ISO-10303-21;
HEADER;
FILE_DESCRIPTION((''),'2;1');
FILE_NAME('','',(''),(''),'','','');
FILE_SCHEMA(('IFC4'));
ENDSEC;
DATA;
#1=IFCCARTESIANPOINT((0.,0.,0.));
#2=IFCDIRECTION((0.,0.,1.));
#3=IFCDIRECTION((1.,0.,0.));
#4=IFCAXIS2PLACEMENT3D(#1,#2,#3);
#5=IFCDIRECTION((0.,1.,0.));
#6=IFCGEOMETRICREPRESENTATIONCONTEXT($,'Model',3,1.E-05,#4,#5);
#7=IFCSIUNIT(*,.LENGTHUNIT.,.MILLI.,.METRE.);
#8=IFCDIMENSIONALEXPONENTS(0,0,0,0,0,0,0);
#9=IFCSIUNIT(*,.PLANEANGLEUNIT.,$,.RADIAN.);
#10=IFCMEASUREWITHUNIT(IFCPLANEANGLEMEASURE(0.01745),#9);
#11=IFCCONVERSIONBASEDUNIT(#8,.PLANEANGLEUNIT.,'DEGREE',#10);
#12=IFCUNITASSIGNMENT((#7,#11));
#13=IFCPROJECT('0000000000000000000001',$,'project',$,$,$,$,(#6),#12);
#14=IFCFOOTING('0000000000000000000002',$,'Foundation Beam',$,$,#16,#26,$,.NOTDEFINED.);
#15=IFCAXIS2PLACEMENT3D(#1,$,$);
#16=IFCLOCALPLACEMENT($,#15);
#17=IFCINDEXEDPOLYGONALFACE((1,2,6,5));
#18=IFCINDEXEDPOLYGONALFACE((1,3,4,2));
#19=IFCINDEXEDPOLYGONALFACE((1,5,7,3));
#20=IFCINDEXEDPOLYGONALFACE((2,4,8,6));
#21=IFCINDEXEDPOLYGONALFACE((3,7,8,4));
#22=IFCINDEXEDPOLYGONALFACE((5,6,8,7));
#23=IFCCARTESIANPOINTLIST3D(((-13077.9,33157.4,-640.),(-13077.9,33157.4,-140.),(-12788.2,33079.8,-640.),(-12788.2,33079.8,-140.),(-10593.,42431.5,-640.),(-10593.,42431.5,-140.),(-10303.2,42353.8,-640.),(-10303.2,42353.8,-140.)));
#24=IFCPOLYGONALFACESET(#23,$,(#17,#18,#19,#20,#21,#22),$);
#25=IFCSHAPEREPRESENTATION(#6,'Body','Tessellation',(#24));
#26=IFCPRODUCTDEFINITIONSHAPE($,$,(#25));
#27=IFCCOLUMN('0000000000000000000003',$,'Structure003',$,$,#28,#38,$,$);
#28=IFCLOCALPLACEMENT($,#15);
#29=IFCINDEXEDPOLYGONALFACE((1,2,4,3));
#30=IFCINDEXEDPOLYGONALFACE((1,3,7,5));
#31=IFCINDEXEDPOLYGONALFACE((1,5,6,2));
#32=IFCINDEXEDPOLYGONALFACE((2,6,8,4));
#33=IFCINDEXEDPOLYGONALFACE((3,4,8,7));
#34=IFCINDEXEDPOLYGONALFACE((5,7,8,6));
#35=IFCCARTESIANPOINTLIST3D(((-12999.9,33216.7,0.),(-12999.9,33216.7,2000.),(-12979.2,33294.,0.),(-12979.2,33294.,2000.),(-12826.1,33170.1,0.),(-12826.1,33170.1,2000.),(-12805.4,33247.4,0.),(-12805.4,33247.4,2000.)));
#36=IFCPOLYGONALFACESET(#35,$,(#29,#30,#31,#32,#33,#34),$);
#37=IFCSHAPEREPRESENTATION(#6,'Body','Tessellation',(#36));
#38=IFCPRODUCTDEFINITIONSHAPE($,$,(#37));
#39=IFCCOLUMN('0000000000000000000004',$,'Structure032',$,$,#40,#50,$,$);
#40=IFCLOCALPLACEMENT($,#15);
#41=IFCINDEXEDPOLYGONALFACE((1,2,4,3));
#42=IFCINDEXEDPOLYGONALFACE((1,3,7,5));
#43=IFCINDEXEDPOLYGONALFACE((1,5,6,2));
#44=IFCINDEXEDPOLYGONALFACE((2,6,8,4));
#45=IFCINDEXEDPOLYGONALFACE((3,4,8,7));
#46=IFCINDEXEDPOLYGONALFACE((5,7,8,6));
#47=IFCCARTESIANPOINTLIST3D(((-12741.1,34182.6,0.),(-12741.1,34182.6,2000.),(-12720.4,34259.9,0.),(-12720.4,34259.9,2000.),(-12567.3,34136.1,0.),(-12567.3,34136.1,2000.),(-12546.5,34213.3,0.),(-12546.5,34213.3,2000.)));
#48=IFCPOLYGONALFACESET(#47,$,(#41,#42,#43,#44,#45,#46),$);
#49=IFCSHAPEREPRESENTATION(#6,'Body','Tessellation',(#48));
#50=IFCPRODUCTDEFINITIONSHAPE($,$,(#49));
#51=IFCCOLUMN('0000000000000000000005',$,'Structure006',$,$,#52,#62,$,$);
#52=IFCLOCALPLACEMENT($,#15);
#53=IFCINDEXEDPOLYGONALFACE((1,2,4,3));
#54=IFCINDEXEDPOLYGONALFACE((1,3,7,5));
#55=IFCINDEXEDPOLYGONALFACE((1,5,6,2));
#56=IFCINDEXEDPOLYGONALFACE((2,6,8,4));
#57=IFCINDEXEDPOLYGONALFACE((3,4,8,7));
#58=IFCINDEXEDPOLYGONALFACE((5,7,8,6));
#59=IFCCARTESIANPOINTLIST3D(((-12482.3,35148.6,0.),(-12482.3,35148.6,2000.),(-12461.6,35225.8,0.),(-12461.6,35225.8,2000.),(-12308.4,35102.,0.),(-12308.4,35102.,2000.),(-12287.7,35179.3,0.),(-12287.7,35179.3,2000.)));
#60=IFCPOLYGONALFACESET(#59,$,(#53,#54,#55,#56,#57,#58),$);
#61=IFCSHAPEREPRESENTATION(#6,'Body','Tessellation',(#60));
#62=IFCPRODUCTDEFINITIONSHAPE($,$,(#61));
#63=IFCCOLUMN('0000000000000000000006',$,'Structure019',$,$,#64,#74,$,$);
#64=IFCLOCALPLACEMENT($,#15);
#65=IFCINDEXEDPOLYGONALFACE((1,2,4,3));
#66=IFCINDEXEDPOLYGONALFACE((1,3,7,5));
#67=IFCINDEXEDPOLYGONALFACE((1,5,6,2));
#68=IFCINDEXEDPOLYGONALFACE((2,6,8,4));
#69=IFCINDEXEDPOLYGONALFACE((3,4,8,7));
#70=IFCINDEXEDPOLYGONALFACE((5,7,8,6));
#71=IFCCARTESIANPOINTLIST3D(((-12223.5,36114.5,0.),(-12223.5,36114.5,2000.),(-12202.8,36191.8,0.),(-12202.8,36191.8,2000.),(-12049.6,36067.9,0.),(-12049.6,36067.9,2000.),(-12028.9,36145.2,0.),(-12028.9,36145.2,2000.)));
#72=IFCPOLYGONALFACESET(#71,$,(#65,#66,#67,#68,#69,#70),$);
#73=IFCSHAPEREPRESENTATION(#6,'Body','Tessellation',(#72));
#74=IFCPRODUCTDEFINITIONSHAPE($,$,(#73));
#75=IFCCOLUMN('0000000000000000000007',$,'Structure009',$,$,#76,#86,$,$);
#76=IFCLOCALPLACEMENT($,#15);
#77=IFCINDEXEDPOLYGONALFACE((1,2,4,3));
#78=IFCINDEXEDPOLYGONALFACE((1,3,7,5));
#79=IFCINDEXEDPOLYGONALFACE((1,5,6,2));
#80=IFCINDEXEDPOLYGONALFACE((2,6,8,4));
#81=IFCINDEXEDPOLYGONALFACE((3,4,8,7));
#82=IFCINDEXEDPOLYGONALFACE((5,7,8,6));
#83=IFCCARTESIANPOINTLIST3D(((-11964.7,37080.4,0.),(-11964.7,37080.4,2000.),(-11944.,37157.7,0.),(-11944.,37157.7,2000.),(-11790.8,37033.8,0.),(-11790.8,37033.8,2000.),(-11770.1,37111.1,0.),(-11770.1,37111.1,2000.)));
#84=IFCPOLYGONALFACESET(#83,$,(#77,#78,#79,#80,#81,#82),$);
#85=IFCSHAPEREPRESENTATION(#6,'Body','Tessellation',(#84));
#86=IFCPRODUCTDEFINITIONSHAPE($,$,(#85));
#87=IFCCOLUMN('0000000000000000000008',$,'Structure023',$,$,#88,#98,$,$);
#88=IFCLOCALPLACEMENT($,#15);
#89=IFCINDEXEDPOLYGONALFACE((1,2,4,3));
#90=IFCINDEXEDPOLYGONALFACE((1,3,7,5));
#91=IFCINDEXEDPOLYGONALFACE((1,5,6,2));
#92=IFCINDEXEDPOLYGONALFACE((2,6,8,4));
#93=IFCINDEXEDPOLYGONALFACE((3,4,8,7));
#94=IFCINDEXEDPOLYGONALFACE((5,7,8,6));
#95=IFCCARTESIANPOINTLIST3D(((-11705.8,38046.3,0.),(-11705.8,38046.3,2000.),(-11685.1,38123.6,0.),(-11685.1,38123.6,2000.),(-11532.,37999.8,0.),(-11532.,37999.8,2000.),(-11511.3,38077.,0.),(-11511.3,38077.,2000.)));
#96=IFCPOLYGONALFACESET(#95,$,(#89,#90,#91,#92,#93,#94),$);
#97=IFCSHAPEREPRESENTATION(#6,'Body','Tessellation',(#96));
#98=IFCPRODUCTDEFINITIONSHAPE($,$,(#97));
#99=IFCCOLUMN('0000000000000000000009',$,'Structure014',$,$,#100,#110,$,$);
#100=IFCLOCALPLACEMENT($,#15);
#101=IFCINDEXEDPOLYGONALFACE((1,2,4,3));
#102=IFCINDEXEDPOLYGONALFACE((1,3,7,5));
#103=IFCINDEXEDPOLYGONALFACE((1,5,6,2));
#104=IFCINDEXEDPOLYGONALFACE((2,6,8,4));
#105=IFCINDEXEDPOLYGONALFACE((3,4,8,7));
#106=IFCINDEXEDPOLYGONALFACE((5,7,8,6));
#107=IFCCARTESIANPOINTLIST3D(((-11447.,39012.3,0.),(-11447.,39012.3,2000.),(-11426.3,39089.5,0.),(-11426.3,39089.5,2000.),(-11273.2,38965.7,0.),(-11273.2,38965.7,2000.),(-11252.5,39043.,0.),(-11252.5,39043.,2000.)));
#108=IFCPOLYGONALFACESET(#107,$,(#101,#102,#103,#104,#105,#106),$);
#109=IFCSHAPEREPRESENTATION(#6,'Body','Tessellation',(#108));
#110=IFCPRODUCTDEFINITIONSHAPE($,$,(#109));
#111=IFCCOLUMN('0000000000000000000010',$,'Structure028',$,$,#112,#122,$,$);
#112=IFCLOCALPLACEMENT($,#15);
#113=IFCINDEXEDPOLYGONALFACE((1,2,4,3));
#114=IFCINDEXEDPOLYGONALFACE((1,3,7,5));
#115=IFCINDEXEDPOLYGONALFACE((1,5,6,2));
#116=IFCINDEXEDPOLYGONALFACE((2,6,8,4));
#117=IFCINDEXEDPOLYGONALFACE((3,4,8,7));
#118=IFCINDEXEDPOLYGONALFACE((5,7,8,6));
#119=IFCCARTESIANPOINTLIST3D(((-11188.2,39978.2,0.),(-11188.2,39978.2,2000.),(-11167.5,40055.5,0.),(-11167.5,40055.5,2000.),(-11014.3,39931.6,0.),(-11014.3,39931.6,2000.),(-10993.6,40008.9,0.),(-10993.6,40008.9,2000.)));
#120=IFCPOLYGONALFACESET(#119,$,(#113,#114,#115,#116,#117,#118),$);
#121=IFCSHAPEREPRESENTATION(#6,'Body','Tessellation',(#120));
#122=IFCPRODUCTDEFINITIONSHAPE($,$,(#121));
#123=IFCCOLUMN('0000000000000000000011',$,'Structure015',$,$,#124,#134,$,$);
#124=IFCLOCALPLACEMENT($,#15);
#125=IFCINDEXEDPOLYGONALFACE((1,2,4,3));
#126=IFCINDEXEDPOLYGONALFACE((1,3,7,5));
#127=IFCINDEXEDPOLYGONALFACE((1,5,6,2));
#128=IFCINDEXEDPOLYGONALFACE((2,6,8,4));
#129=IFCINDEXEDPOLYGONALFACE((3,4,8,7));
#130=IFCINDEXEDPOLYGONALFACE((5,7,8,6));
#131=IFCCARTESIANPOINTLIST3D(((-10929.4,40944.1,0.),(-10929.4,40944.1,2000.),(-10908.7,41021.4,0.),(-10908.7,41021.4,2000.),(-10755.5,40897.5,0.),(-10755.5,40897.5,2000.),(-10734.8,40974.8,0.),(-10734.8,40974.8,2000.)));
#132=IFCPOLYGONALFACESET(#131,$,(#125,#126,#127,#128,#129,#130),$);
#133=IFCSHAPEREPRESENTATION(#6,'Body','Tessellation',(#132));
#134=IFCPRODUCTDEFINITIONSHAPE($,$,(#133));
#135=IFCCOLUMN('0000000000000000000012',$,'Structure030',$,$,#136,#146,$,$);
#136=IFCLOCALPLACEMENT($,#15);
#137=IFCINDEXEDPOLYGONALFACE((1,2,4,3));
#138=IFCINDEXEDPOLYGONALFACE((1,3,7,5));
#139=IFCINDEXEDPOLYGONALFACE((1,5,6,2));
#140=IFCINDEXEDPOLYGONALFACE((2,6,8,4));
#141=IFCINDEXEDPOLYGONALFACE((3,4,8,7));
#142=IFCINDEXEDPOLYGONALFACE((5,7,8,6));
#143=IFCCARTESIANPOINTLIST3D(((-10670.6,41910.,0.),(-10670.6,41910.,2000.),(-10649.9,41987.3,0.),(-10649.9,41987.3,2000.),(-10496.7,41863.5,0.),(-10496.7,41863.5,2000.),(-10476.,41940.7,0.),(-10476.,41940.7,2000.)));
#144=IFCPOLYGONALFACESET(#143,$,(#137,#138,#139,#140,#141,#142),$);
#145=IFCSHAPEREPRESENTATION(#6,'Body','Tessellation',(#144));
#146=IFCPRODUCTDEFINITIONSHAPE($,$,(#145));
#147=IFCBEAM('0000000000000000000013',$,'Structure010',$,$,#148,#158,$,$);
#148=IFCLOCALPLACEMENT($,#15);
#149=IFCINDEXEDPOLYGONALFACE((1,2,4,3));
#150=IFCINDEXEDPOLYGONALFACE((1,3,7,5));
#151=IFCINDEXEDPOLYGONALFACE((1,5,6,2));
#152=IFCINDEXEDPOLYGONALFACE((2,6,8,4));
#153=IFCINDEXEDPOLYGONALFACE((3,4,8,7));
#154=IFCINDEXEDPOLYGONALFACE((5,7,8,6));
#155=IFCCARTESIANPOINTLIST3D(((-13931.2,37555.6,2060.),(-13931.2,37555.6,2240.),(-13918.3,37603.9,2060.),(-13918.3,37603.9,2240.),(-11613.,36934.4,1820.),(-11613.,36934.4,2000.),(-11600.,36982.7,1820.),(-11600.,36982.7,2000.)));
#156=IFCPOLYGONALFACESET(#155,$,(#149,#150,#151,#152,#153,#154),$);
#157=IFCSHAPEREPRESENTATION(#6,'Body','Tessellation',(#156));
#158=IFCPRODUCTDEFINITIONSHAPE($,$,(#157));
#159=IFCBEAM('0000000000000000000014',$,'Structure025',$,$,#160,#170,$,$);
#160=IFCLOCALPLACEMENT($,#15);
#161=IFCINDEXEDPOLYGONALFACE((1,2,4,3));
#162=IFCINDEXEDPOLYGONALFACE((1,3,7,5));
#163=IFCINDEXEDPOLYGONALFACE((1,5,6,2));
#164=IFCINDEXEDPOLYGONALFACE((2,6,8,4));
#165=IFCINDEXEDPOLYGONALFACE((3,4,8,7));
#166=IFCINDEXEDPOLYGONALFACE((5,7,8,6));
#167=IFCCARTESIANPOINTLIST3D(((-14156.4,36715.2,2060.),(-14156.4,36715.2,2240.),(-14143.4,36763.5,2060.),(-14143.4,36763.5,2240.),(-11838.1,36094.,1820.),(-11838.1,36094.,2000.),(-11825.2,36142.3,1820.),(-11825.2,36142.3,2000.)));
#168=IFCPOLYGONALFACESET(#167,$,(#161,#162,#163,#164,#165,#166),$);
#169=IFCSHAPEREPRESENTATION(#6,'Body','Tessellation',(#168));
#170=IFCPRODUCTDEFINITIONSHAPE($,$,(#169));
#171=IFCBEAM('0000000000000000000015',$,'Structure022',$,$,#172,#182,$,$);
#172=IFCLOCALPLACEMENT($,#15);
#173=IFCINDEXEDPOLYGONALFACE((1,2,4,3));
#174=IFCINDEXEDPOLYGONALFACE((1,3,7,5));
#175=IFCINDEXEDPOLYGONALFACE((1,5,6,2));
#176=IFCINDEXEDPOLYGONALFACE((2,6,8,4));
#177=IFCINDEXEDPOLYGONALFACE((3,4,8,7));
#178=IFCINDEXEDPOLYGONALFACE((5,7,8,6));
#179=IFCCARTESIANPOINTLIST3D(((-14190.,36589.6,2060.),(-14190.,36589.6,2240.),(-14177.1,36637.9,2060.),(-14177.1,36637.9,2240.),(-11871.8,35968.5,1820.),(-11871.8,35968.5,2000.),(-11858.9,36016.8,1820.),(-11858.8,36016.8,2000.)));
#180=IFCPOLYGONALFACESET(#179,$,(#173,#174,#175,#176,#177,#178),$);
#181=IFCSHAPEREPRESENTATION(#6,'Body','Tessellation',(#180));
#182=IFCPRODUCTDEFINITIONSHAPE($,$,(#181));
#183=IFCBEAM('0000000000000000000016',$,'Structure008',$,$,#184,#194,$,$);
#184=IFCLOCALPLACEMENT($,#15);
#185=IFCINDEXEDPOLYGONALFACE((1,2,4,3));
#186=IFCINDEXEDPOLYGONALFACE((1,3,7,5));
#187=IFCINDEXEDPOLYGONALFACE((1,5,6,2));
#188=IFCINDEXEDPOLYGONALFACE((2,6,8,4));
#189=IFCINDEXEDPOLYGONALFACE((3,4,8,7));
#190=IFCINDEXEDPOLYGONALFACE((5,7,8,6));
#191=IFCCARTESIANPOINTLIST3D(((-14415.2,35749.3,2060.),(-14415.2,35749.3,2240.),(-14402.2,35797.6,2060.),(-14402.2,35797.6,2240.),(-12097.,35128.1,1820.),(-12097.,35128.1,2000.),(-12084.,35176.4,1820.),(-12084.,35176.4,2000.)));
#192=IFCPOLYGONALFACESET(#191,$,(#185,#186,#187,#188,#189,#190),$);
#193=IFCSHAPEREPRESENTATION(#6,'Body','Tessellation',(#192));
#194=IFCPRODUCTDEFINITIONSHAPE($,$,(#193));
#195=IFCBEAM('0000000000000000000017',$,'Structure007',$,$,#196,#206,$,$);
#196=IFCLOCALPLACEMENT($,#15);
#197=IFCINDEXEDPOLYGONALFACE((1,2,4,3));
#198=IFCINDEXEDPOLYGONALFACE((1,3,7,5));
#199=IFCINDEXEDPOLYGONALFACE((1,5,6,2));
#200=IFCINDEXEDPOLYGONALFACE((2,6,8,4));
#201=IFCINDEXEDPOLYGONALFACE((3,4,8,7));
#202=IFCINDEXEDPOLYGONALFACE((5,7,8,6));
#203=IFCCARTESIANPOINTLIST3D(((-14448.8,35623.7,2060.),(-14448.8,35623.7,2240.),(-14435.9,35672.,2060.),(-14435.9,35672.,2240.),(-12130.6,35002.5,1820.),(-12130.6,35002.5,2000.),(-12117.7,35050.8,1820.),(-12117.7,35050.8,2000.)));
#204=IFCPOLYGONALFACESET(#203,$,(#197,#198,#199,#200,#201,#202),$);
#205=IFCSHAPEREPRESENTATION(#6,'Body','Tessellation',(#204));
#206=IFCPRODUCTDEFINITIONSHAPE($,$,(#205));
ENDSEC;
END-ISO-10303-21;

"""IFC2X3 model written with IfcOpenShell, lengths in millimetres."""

from ifc_helpers import new_model, entity, si_unit, converted_unit, direction, frame, origin_with_axes, place, context, project, polyline, outline, extrude, element, save


model = new_model("IFC2X3")

# Units and contexts
model_context = context("Model", 3, precision=1e-05, world=origin_with_axes(), true_north=direction((0.0, 1.0, 0.0)))
ifc_project = project(units=[si_unit("LENGTHUNIT", "METRE", prefix="MILLI"), converted_unit("PLANEANGLEUNIT", "DEGREE", entity("IfcPlaneAngleMeasure", 0.01745), si_unit("PLANEANGLEUNIT", "RADIAN"), dimensions=[0, 0, 0, 0, 0, 0, 0])], contexts=[model_context])

# Footing
footing_placement = place(None, origin_with_axes())
element("IfcFooting", 1, at=footing_placement, Name="Foundation Beam", PredefinedType="NOTDEFINED", context=model_context, shape_type="SweptSolid", body=[
    extrude(outline(polyline([(0.0, 0.0), (300.0, 0.0), (300.0, 500.0), (0.0, 500.0), (0.0, 0.0)])), frame((-10593.0, 42431.5, -640.0), z_axis=(-0.258819, -0.965926, 0.0), x_axis=(0.965926, -0.258819, 0.0)), (0.0, 0.0, 1.0), 9601.2),
])

# Columns
column_1_placement = place(None, origin_with_axes())
element("IfcColumn", 2, at=column_1_placement, Name="Structure003", context=model_context, shape_type="SweptSolid", body=[
    extrude(outline(polyline([(-90.0, -40.0), (90.0, -40.0), (90.0, 40.0), (-90.0, 40.0), (-90.0, -40.0)])), frame((-12902.7, 33232.1, 0.0), z_axis=(0.0, 0.0, 1.0), x_axis=(0.965926, -0.258819, 0.0)), (0.0, 0.0, 1.0), 2000.0),
])
column_2_placement = place(None, origin_with_axes())
element("IfcColumn", 3, at=column_2_placement, Name="Structure032", context=model_context, shape_type="SweptSolid", body=[
    extrude(outline(polyline([(-90.0, -40.0), (90.0, -40.0), (90.0, 40.0), (-90.0, 40.0), (-90.0, -40.0)])), frame((-12643.8, 34198.0, 0.0), z_axis=(0.0, 0.0, 1.0), x_axis=(0.965926, -0.258819, 0.0)), (0.0, 0.0, 1.0), 2000.0),
])
column_3_placement = place(None, origin_with_axes())
element("IfcColumn", 4, at=column_3_placement, Name="Structure006", context=model_context, shape_type="SweptSolid", body=[
    extrude(outline(polyline([(-90.0, -40.0), (90.0, -40.0), (90.0, 40.0), (-90.0, 40.0), (-90.0, -40.0)])), frame((-12385.0, 35163.9, 0.0), z_axis=(0.0, 0.0, 1.0), x_axis=(0.965926, -0.258819, 0.0)), (0.0, 0.0, 1.0), 2000.0),
])
column_4_placement = place(None, origin_with_axes())
element("IfcColumn", 5, at=column_4_placement, Name="Structure019", context=model_context, shape_type="SweptSolid", body=[
    extrude(outline(polyline([(-90.0, -40.0), (90.0, -40.0), (90.0, 40.0), (-90.0, 40.0), (-90.0, -40.0)])), frame((-12126.2, 36129.8, 0.0), z_axis=(0.0, 0.0, 1.0), x_axis=(0.965926, -0.258819, 0.0)), (0.0, 0.0, 1.0), 2000.0),
])
column_5_placement = place(None, origin_with_axes())
element("IfcColumn", 6, at=column_5_placement, Name="Structure009", context=model_context, shape_type="SweptSolid", body=[
    extrude(outline(polyline([(-90.0, -40.0), (90.0, -40.0), (90.0, 40.0), (-90.0, 40.0), (-90.0, -40.0)])), frame((-11867.4, 37095.8, 0.0), z_axis=(0.0, 0.0, 1.0), x_axis=(0.965926, -0.258819, 0.0)), (0.0, 0.0, 1.0), 2000.0),
])
column_6_placement = place(None, origin_with_axes())
element("IfcColumn", 7, at=column_6_placement, Name="Structure023", context=model_context, shape_type="SweptSolid", body=[
    extrude(outline(polyline([(-90.0, -40.0), (90.0, -40.0), (90.0, 40.0), (-90.0, 40.0), (-90.0, -40.0)])), frame((-11608.6, 38061.7, 0.0), z_axis=(0.0, 0.0, 1.0), x_axis=(0.965926, -0.258819, 0.0)), (0.0, 0.0, 1.0), 2000.0),
])
column_7_placement = place(None, origin_with_axes())
element("IfcColumn", 8, at=column_7_placement, Name="Structure014", context=model_context, shape_type="SweptSolid", body=[
    extrude(outline(polyline([(-90.0, -40.0), (90.0, -40.0), (90.0, 40.0), (-90.0, 40.0), (-90.0, -40.0)])), frame((-11349.7, 39027.6, 0.0), z_axis=(0.0, 0.0, 1.0), x_axis=(0.965926, -0.258819, 0.0)), (0.0, 0.0, 1.0), 2000.0),
])
column_8_placement = place(None, origin_with_axes())
element("IfcColumn", 9, at=column_8_placement, Name="Structure028", context=model_context, shape_type="SweptSolid", body=[
    extrude(outline(polyline([(-90.0, -40.0), (90.0, -40.0), (90.0, 40.0), (-90.0, 40.0), (-90.0, -40.0)])), frame((-11090.9, 39993.5, 0.0), z_axis=(0.0, 0.0, 1.0), x_axis=(0.965926, -0.258819, 0.0)), (0.0, 0.0, 1.0), 2000.0),
])
column_9_placement = place(None, origin_with_axes())
element("IfcColumn", 10, at=column_9_placement, Name="Structure015", context=model_context, shape_type="SweptSolid", body=[
    extrude(outline(polyline([(-90.0, -40.0), (90.0, -40.0), (90.0, 40.0), (-90.0, 40.0), (-90.0, -40.0)])), frame((-10832.1, 40959.5, 0.0), z_axis=(0.0, 0.0, 1.0), x_axis=(0.965926, -0.258819, 0.0)), (0.0, 0.0, 1.0), 2000.0),
])
column_10_placement = place(None, origin_with_axes())
element("IfcColumn", 11, at=column_10_placement, Name="Structure030", context=model_context, shape_type="SweptSolid", body=[
    extrude(outline(polyline([(-90.0, -40.0), (90.0, -40.0), (90.0, 40.0), (-90.0, 40.0), (-90.0, -40.0)])), frame((-10573.3, 41925.4, 0.0), z_axis=(0.0, 0.0, 1.0), x_axis=(0.965926, -0.258819, 0.0)), (0.0, 0.0, 1.0), 2000.0),
])

# Beams
beam_1_placement = place(None, origin_with_axes())
element("IfcBeam", 12, at=beam_1_placement, Name="Structure010", context=model_context, shape_type="SweptSolid", body=[
    extrude(outline(polyline([(-90.0, -25.0), (90.0, -25.0), (90.0, 25.0), (-90.0, 25.0), (-90.0, -25.0)])), frame((-13924.7, 37579.7, 2150.0), z_axis=(0.965926, -0.258818, 0.0), x_axis=(0.0, 0.0, -1.0)), (0.099504, 0.0, 0.995037), 2412.0),
])
beam_2_placement = place(None, origin_with_axes())
element("IfcBeam", 13, at=beam_2_placement, Name="Structure025", context=model_context, shape_type="SweptSolid", body=[
    extrude(outline(polyline([(-90.0, -25.0), (90.0, -25.0), (90.0, 25.0), (-90.0, 25.0), (-90.0, -25.0)])), frame((-14149.9, 36739.3, 2150.0), z_axis=(0.965926, -0.258818, 0.0), x_axis=(0.0, 0.0, -1.0)), (0.099504, 0.0, 0.995037), 2412.0),
])
beam_3_placement = place(None, origin_with_axes())
element("IfcBeam", 14, at=beam_3_placement, Name="Structure022", context=model_context, shape_type="SweptSolid", body=[
    extrude(outline(polyline([(-90.0, -25.0), (90.0, -25.0), (90.0, 25.0), (-90.0, 25.0), (-90.0, -25.0)])), frame((-14183.5, 36613.8, 2150.0), z_axis=(0.965926, -0.258818, 0.0), x_axis=(0.0, 0.0, -1.0)), (0.099504, 0.0, 0.995037), 2412.0),
])
beam_4_placement = place(None, origin_with_axes())
element("IfcBeam", 15, at=beam_4_placement, Name="Structure008", context=model_context, shape_type="SweptSolid", body=[
    extrude(outline(polyline([(-90.0, -25.0), (90.0, -25.0), (90.0, 25.0), (-90.0, 25.0), (-90.0, -25.0)])), frame((-14408.7, 35773.4, 2150.0), z_axis=(0.965926, -0.258818, 0.0), x_axis=(0.0, 0.0, -1.0)), (0.099504, 0.0, 0.995037), 2412.0),
])
beam_5_placement = place(None, origin_with_axes())
element("IfcBeam", 16, at=beam_5_placement, Name="Structure007", context=model_context, shape_type="SweptSolid", body=[
    extrude(outline(polyline([(-90.0, -25.0), (90.0, -25.0), (90.0, 25.0), (-90.0, 25.0), (-90.0, -25.0)])), frame((-14442.4, 35647.9, 2150.0), z_axis=(0.965926, -0.258818, 0.0), x_axis=(0.0, 0.0, -1.0)), (0.099504, 0.0, 0.995037), 2412.0),
])

save(model, "model.ifc")
